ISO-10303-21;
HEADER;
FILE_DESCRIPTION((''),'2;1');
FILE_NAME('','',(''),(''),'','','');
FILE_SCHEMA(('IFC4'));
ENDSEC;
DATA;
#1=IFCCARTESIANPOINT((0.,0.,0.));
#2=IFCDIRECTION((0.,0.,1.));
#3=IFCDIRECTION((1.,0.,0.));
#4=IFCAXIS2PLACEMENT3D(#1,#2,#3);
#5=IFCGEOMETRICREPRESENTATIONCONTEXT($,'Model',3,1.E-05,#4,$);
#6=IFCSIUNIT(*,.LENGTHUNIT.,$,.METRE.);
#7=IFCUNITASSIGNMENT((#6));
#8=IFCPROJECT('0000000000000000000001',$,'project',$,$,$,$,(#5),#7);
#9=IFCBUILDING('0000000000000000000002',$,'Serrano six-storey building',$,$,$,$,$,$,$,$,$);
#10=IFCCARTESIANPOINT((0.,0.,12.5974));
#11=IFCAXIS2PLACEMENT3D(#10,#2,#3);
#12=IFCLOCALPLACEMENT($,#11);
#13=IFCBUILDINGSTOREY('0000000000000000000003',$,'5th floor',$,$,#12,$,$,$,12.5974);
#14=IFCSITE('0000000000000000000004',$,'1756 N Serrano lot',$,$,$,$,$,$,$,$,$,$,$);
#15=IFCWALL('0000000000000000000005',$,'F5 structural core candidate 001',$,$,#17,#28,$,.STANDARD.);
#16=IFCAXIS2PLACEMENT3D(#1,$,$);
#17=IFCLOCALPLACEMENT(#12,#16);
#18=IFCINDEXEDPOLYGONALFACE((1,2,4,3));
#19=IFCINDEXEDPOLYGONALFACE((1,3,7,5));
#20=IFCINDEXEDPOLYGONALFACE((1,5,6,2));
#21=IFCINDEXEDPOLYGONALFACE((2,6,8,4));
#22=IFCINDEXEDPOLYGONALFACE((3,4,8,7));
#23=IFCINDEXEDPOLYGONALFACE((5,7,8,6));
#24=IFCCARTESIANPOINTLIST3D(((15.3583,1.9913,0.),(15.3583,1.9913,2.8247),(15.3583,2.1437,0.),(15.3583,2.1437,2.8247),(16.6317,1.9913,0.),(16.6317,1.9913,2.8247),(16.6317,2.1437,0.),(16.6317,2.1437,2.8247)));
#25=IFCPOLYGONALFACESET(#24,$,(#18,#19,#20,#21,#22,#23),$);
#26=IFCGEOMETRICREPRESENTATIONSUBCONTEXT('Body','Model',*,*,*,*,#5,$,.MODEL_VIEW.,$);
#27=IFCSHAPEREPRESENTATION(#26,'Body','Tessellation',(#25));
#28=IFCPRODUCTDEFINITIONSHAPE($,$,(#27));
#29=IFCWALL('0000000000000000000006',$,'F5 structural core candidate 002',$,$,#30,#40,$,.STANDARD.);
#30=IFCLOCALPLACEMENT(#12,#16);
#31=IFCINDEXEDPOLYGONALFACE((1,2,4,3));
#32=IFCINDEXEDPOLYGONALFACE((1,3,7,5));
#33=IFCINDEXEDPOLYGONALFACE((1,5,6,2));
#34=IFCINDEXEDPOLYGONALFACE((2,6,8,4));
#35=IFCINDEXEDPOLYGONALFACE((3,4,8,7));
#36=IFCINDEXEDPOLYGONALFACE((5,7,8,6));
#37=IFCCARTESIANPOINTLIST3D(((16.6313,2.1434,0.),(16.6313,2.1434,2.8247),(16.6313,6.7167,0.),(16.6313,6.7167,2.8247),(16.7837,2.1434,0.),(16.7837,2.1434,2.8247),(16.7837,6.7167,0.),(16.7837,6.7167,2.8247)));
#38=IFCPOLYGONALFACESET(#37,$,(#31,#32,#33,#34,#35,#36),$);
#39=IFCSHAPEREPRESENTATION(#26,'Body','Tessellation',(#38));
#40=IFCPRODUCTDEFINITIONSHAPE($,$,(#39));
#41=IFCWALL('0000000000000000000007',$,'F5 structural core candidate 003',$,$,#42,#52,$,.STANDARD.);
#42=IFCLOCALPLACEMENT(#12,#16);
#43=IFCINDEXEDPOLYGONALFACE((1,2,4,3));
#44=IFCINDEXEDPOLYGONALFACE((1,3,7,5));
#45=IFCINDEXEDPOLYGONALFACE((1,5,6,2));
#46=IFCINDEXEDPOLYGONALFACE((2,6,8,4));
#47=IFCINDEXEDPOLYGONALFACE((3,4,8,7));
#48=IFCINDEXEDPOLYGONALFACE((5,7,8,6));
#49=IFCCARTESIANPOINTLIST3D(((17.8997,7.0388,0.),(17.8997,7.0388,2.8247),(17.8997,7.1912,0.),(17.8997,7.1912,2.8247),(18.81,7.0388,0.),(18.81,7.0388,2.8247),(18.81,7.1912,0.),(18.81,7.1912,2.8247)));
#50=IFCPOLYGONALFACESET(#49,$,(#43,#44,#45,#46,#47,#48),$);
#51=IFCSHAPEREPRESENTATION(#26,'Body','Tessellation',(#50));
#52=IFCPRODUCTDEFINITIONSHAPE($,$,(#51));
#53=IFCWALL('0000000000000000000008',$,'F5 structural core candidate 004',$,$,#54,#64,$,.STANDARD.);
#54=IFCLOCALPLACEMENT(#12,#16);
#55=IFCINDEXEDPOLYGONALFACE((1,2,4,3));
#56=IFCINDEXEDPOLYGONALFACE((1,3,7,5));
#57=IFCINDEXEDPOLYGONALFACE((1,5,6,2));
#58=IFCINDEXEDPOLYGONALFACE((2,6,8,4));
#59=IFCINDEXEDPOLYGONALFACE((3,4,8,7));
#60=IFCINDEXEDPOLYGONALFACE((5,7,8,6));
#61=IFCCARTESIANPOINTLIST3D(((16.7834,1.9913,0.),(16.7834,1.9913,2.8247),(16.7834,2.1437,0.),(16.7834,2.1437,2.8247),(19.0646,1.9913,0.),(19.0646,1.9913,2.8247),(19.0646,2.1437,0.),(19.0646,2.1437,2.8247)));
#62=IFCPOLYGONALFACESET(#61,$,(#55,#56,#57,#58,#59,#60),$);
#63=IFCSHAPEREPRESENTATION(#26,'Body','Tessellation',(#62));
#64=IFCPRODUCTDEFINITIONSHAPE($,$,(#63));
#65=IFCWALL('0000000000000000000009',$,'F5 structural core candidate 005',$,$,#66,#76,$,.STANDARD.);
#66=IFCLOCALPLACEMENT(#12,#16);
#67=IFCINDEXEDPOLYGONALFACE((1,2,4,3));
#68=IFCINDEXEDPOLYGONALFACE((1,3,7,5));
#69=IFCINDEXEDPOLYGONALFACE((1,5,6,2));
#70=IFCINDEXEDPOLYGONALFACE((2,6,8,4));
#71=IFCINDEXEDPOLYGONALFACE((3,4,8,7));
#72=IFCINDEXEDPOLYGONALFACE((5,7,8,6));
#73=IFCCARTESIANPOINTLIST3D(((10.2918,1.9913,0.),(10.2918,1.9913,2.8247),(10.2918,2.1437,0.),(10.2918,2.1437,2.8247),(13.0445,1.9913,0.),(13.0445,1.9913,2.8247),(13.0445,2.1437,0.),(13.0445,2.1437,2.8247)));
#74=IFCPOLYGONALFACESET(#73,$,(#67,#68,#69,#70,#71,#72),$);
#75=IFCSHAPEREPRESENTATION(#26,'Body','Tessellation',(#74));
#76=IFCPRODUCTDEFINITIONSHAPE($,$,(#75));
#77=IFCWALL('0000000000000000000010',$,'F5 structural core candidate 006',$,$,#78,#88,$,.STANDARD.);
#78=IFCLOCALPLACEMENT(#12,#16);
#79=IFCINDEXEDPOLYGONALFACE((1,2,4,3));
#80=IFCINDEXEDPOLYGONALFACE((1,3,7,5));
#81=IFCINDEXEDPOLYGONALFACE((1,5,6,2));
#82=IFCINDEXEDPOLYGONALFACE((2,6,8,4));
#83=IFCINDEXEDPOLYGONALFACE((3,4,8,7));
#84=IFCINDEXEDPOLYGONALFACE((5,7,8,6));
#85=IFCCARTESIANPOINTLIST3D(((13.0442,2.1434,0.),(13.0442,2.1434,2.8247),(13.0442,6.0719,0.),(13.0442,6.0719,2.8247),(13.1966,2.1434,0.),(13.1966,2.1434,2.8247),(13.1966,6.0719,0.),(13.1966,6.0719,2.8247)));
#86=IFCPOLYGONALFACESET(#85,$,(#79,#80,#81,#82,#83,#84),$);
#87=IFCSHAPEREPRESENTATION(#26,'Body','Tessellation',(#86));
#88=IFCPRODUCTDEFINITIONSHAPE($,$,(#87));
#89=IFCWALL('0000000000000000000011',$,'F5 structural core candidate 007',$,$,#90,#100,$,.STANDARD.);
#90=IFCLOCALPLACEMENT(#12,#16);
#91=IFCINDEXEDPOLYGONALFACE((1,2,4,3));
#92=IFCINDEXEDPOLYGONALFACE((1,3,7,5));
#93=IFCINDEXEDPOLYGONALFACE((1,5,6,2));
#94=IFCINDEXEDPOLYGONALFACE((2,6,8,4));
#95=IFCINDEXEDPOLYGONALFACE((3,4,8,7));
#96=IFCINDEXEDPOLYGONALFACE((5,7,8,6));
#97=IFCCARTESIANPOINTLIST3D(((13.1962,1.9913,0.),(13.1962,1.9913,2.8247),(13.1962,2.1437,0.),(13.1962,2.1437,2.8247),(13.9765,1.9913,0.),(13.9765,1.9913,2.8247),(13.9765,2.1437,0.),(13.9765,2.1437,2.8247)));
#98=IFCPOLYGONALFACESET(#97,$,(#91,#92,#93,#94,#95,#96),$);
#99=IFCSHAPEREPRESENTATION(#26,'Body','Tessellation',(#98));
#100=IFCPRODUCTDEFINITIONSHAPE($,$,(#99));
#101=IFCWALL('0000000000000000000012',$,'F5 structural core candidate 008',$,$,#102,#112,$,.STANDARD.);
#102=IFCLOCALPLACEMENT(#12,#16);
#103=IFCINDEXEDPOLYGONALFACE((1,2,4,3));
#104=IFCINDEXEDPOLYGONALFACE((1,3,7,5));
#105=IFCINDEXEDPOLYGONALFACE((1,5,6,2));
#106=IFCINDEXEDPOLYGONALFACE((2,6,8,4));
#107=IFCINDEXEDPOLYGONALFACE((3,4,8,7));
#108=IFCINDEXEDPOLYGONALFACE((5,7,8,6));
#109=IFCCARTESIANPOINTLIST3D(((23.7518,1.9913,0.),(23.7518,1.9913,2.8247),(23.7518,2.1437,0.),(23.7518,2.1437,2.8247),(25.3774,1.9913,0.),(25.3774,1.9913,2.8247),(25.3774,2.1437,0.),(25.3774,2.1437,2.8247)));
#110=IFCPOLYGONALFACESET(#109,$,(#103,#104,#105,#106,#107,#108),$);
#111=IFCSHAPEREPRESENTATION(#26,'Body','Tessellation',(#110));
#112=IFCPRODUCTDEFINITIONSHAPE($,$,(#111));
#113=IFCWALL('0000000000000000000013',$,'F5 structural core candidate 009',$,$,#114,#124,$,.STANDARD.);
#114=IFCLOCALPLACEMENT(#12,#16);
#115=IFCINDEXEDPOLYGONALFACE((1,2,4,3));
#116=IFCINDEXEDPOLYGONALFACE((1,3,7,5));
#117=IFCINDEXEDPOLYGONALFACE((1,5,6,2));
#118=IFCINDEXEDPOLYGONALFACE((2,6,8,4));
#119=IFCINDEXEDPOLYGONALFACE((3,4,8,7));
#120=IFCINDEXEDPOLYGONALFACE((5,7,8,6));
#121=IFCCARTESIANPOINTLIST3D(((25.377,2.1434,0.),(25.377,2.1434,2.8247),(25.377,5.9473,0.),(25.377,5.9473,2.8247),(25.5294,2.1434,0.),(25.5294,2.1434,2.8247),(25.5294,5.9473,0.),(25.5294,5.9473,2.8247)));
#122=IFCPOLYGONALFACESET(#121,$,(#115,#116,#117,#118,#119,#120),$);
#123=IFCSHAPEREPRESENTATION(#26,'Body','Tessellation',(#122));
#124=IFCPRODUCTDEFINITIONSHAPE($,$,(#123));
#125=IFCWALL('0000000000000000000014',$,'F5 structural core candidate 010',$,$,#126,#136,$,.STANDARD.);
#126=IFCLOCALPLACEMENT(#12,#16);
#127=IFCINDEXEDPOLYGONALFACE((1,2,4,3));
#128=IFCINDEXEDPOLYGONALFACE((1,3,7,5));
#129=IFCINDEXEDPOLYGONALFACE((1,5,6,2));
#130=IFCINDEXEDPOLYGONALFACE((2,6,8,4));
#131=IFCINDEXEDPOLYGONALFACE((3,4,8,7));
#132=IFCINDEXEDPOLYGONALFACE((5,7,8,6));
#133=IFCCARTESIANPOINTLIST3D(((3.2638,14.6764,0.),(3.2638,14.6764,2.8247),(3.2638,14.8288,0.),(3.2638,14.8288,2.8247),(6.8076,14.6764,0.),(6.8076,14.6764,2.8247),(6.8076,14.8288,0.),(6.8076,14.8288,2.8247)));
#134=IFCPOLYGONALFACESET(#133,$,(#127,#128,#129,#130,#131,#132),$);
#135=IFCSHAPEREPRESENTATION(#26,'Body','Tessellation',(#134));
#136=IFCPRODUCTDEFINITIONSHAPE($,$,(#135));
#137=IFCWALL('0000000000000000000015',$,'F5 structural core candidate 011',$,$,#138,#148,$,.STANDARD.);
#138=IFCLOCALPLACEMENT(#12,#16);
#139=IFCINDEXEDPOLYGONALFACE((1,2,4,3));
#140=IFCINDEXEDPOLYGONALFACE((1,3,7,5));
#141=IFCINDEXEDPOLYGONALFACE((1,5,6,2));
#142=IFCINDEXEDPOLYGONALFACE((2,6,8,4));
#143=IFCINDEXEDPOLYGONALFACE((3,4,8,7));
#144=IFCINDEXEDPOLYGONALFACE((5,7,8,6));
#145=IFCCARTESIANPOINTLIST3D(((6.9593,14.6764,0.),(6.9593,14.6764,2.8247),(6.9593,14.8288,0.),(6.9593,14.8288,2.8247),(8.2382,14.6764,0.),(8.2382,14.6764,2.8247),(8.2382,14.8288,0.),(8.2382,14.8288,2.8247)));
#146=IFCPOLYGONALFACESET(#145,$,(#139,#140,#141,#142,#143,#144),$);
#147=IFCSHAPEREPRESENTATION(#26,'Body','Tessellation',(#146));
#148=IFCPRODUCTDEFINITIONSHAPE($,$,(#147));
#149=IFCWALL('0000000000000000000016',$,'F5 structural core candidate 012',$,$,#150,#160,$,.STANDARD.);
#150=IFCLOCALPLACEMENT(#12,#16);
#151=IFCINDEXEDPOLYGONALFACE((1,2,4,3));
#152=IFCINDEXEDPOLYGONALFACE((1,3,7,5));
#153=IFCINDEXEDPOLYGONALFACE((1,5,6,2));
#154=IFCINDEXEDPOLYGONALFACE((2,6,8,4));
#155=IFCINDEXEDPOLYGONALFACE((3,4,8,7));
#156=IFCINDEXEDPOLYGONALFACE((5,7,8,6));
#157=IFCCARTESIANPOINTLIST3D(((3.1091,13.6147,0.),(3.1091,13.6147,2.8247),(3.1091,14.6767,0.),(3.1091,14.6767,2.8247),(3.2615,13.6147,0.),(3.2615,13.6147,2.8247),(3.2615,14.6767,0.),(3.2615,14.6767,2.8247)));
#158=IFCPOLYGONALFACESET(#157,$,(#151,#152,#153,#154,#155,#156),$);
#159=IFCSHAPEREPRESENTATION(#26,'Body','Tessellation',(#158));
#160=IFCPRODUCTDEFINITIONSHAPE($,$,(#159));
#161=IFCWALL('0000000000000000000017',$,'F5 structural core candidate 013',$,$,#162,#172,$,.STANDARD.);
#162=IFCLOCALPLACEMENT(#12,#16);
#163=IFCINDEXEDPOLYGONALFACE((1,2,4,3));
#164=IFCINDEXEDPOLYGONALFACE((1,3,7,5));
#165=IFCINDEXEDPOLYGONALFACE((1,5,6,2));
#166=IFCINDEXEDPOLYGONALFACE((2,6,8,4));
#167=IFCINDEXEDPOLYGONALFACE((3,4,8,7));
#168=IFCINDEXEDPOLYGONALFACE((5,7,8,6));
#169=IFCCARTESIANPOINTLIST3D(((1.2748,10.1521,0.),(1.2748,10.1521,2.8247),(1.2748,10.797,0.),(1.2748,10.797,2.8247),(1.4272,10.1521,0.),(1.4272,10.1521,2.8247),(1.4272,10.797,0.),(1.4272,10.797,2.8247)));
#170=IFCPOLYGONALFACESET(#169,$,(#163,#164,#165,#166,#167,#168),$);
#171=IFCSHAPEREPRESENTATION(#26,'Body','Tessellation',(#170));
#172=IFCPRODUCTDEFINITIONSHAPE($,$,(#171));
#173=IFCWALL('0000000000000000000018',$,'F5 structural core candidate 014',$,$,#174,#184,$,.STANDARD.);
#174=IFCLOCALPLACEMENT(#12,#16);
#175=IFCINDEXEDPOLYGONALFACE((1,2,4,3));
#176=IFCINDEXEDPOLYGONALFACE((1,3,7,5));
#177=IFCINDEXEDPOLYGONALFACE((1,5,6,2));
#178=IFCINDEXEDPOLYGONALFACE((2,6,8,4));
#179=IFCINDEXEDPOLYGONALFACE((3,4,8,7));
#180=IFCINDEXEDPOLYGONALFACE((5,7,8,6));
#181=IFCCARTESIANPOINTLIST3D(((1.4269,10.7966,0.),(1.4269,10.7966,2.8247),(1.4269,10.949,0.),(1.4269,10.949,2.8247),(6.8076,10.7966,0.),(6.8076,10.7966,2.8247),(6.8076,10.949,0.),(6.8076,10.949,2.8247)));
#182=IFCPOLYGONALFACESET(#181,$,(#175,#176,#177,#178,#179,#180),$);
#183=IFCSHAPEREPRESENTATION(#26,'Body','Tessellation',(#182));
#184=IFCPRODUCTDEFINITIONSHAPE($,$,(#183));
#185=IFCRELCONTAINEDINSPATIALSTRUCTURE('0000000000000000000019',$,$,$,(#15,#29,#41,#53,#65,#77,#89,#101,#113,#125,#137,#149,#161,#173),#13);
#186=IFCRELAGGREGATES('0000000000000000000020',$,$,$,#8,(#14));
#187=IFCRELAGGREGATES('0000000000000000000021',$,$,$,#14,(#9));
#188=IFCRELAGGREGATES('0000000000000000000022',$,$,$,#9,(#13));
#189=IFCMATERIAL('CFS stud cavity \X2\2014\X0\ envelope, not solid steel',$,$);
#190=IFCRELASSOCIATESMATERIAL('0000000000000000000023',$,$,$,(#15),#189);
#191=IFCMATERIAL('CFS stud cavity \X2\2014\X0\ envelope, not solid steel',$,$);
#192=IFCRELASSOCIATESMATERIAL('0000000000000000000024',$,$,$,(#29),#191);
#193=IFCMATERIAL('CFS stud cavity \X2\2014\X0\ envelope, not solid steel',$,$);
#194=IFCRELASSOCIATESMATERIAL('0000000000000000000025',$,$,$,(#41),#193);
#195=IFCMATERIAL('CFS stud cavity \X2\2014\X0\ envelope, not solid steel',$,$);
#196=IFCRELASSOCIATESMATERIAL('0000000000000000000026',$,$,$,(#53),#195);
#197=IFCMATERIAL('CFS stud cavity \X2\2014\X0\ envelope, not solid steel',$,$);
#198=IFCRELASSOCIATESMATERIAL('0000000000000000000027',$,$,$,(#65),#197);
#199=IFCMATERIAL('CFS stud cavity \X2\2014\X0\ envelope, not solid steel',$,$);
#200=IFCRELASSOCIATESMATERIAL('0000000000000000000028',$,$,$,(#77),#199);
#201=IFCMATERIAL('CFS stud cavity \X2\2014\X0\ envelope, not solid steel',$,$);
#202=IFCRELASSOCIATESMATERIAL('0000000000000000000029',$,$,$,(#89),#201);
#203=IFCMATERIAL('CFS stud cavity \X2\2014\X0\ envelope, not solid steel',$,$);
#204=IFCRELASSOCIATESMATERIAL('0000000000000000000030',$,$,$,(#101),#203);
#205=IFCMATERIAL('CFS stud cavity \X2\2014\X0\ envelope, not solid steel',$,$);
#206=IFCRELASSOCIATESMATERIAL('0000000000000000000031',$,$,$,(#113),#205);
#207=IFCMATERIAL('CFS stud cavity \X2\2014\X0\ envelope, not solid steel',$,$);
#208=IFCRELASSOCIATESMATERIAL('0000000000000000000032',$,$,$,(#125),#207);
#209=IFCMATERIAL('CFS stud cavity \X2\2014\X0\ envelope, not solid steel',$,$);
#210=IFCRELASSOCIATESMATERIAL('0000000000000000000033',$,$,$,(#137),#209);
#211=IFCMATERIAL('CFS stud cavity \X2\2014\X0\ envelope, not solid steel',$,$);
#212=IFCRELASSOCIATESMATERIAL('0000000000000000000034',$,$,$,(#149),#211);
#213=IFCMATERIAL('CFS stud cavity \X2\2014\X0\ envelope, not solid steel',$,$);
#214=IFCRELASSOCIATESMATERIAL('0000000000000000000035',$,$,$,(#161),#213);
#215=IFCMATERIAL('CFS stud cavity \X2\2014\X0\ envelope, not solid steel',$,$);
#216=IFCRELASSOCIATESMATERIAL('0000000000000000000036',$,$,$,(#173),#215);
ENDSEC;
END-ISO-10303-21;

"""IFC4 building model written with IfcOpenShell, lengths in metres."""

from ifc_helpers import new_model, si_unit, frame, origin_with_axes, place, context, subcontext, project, spatial, polyline, outline, extrude, material, element, save


model = new_model("IFC4")

# Units and contexts
model_context = context("Model", 3, precision=1e-05, world=origin_with_axes())
body_context = subcontext(model_context, "Body", "Model", "MODEL_VIEW")
ifc_project = project(units=[si_unit("LENGTHUNIT", "METRE")], contexts=[model_context])

# Site, building, storey
site = spatial("IfcSite", under=ifc_project, Name="1756 N Serrano lot")
building = spatial("IfcBuilding", under=site, Name="Serrano six-storey building")
storey_placement = place(None, frame((0.0, 0.0, 12.5974), z_axis=(0.0, 0.0, 1.0), x_axis=(1.0, 0.0, 0.0)))
storey = spatial("IfcBuildingStorey", under=building, at=storey_placement, Name="5th floor", Elevation=12.5974)

# Walls
ifc_material_1 = material(Name="CFS stud cavity — envelope, not solid steel")
wall_1_placement = place(storey_placement, frame((0.0, 0.0, -12.5974), z_axis=(0.0, 0.0, 1.0), x_axis=(1.0, 0.0, 0.0)))
element("IfcWall", 1, at=wall_1_placement, inside=storey, material=ifc_material_1, Name="F5 structural core candidate 001", PredefinedType="STANDARD", context=body_context, shape_type="SweptSolid", body=[
    extrude(outline(polyline([(16.6317, 2.1437), (16.6317, 1.9913), (15.3583, 1.9913), (15.3583, 2.1437), (16.6317, 2.1437)])), frame((0.0, 0.0, 12.5974)), (0.0, 0.0, 1.0), 2.8247),
])
ifc_material_2 = material(Name="CFS stud cavity — envelope, not solid steel")
wall_2_placement = place(storey_placement, frame((0.0, 0.0, -12.5974), z_axis=(0.0, 0.0, 1.0), x_axis=(1.0, 0.0, 0.0)))
element("IfcWall", 2, at=wall_2_placement, inside=storey, material=ifc_material_2, Name="F5 structural core candidate 002", PredefinedType="STANDARD", context=body_context, shape_type="SweptSolid", body=[
    extrude(outline(polyline([(16.7837, 2.1434), (16.6313, 2.1434), (16.6313, 6.7167), (16.7837, 6.7167), (16.7837, 2.1434)])), frame((0.0, 0.0, 12.5974)), (0.0, 0.0, 1.0), 2.8247),
])
ifc_material_3 = material(Name="CFS stud cavity — envelope, not solid steel")
wall_3_placement = place(storey_placement, frame((0.0, 0.0, -12.5974), z_axis=(0.0, 0.0, 1.0), x_axis=(1.0, 0.0, 0.0)))
element("IfcWall", 3, at=wall_3_placement, inside=storey, material=ifc_material_3, Name="F5 structural core candidate 003", PredefinedType="STANDARD", context=body_context, shape_type="SweptSolid", body=[
    extrude(outline(polyline([(18.81, 7.1912), (18.81, 7.0388), (17.8997, 7.0388), (17.8997, 7.1912), (18.81, 7.1912)])), frame((0.0, 0.0, 12.5974)), (0.0, 0.0, 1.0), 2.8247),
])
ifc_material_4 = material(Name="CFS stud cavity — envelope, not solid steel")
wall_4_placement = place(storey_placement, frame((0.0, 0.0, -12.5974), z_axis=(0.0, 0.0, 1.0), x_axis=(1.0, 0.0, 0.0)))
element("IfcWall", 4, at=wall_4_placement, inside=storey, material=ifc_material_4, Name="F5 structural core candidate 004", PredefinedType="STANDARD", context=body_context, shape_type="SweptSolid", body=[
    extrude(outline(polyline([(19.0646, 2.1437), (19.0646, 1.9913), (16.7834, 1.9913), (16.7834, 2.1437), (19.0646, 2.1437)])), frame((0.0, 0.0, 12.5974)), (0.0, 0.0, 1.0), 2.8247),
])
ifc_material_5 = material(Name="CFS stud cavity — envelope, not solid steel")
wall_5_placement = place(storey_placement, frame((0.0, 0.0, -12.5974), z_axis=(0.0, 0.0, 1.0), x_axis=(1.0, 0.0, 0.0)))
element("IfcWall", 5, at=wall_5_placement, inside=storey, material=ifc_material_5, Name="F5 structural core candidate 005", PredefinedType="STANDARD", context=body_context, shape_type="SweptSolid", body=[
    extrude(outline(polyline([(13.0445, 2.1437), (13.0445, 1.9913), (10.2918, 1.9913), (10.2918, 2.1437), (13.0445, 2.1437)])), frame((0.0, 0.0, 12.5974)), (0.0, 0.0, 1.0), 2.8247),
])
ifc_material_6 = material(Name="CFS stud cavity — envelope, not solid steel")
wall_6_placement = place(storey_placement, frame((0.0, 0.0, -12.5974), z_axis=(0.0, 0.0, 1.0), x_axis=(1.0, 0.0, 0.0)))
element("IfcWall", 6, at=wall_6_placement, inside=storey, material=ifc_material_6, Name="F5 structural core candidate 006", PredefinedType="STANDARD", context=body_context, shape_type="SweptSolid", body=[
    extrude(outline(polyline([(13.1966, 2.1434), (13.0442, 2.1434), (13.0442, 6.0719), (13.1966, 6.0719), (13.1966, 2.1434)])), frame((0.0, 0.0, 12.5974)), (0.0, 0.0, 1.0), 2.8247),
])
ifc_material_7 = material(Name="CFS stud cavity — envelope, not solid steel")
wall_7_placement = place(storey_placement, frame((0.0, 0.0, -12.5974), z_axis=(0.0, 0.0, 1.0), x_axis=(1.0, 0.0, 0.0)))
element("IfcWall", 7, at=wall_7_placement, inside=storey, material=ifc_material_7, Name="F5 structural core candidate 007", PredefinedType="STANDARD", context=body_context, shape_type="SweptSolid", body=[
    extrude(outline(polyline([(13.9765, 2.1437), (13.9765, 1.9913), (13.1962, 1.9913), (13.1962, 2.1437), (13.9765, 2.1437)])), frame((0.0, 0.0, 12.5974)), (0.0, 0.0, 1.0), 2.8247),
])
ifc_material_8 = material(Name="CFS stud cavity — envelope, not solid steel")
wall_8_placement = place(storey_placement, frame((0.0, 0.0, -12.5974), z_axis=(0.0, 0.0, 1.0), x_axis=(1.0, 0.0, 0.0)))
element("IfcWall", 8, at=wall_8_placement, inside=storey, material=ifc_material_8, Name="F5 structural core candidate 008", PredefinedType="STANDARD", context=body_context, shape_type="SweptSolid", body=[
    extrude(outline(polyline([(25.3774, 2.1437), (25.3774, 1.9913), (23.7518, 1.9913), (23.7518, 2.1437), (25.3774, 2.1437)])), frame((0.0, 0.0, 12.5974)), (0.0, 0.0, 1.0), 2.8247),
])
ifc_material_9 = material(Name="CFS stud cavity — envelope, not solid steel")
wall_9_placement = place(storey_placement, frame((0.0, 0.0, -12.5974), z_axis=(0.0, 0.0, 1.0), x_axis=(1.0, 0.0, 0.0)))
element("IfcWall", 9, at=wall_9_placement, inside=storey, material=ifc_material_9, Name="F5 structural core candidate 009", PredefinedType="STANDARD", context=body_context, shape_type="SweptSolid", body=[
    extrude(outline(polyline([(25.5294, 2.1434), (25.377, 2.1434), (25.377, 5.9473), (25.5294, 5.9473), (25.5294, 2.1434)])), frame((0.0, 0.0, 12.5974)), (0.0, 0.0, 1.0), 2.8247),
])
ifc_material_10 = material(Name="CFS stud cavity — envelope, not solid steel")
wall_10_placement = place(storey_placement, frame((0.0, 0.0, -12.5974), z_axis=(0.0, 0.0, 1.0), x_axis=(1.0, 0.0, 0.0)))
element("IfcWall", 10, at=wall_10_placement, inside=storey, material=ifc_material_10, Name="F5 structural core candidate 010", PredefinedType="STANDARD", context=body_context, shape_type="SweptSolid", body=[
    extrude(outline(polyline([(6.8076, 14.8288), (6.8076, 14.6764), (3.2638, 14.6764), (3.2638, 14.8288), (6.8076, 14.8288)])), frame((0.0, 0.0, 12.5974)), (0.0, 0.0, 1.0), 2.8247),
])
ifc_material_11 = material(Name="CFS stud cavity — envelope, not solid steel")
wall_11_placement = place(storey_placement, frame((0.0, 0.0, -12.5974), z_axis=(0.0, 0.0, 1.0), x_axis=(1.0, 0.0, 0.0)))
element("IfcWall", 11, at=wall_11_placement, inside=storey, material=ifc_material_11, Name="F5 structural core candidate 011", PredefinedType="STANDARD", context=body_context, shape_type="SweptSolid", body=[
    extrude(outline(polyline([(8.2382, 14.8288), (8.2382, 14.6764), (6.9593, 14.6764), (6.9593, 14.8288), (8.2382, 14.8288)])), frame((0.0, 0.0, 12.5974)), (0.0, 0.0, 1.0), 2.8247),
])
ifc_material_12 = material(Name="CFS stud cavity — envelope, not solid steel")
wall_12_placement = place(storey_placement, frame((0.0, 0.0, -12.5974), z_axis=(0.0, 0.0, 1.0), x_axis=(1.0, 0.0, 0.0)))
element("IfcWall", 12, at=wall_12_placement, inside=storey, material=ifc_material_12, Name="F5 structural core candidate 012", PredefinedType="STANDARD", context=body_context, shape_type="SweptSolid", body=[
    extrude(outline(polyline([(3.2615, 13.6147), (3.1091, 13.6147), (3.1091, 14.6767), (3.2615, 14.6767), (3.2615, 13.6147)])), frame((0.0, 0.0, 12.5974)), (0.0, 0.0, 1.0), 2.8247),
])
ifc_material_13 = material(Name="CFS stud cavity — envelope, not solid steel")
wall_13_placement = place(storey_placement, frame((0.0, 0.0, -12.5974), z_axis=(0.0, 0.0, 1.0), x_axis=(1.0, 0.0, 0.0)))
element("IfcWall", 13, at=wall_13_placement, inside=storey, material=ifc_material_13, Name="F5 structural core candidate 013", PredefinedType="STANDARD", context=body_context, shape_type="SweptSolid", body=[
    extrude(outline(polyline([(1.4272, 10.1521), (1.2748, 10.1521), (1.2748, 10.797), (1.4272, 10.797), (1.4272, 10.1521)])), frame((0.0, 0.0, 12.5974)), (0.0, 0.0, 1.0), 2.8247),
])
ifc_material_14 = material(Name="CFS stud cavity — envelope, not solid steel")
wall_14_placement = place(storey_placement, frame((0.0, 0.0, -12.5974), z_axis=(0.0, 0.0, 1.0), x_axis=(1.0, 0.0, 0.0)))
element("IfcWall", 14, at=wall_14_placement, inside=storey, material=ifc_material_14, Name="F5 structural core candidate 014", PredefinedType="STANDARD", context=body_context, shape_type="SweptSolid", body=[
    extrude(outline(polyline([(6.8076, 10.949), (6.8076, 10.7966), (1.4269, 10.7966), (1.4269, 10.949), (6.8076, 10.949)])), frame((0.0, 0.0, 12.5974)), (0.0, 0.0, 1.0), 2.8247),
])

save(model, "model.ifc")
